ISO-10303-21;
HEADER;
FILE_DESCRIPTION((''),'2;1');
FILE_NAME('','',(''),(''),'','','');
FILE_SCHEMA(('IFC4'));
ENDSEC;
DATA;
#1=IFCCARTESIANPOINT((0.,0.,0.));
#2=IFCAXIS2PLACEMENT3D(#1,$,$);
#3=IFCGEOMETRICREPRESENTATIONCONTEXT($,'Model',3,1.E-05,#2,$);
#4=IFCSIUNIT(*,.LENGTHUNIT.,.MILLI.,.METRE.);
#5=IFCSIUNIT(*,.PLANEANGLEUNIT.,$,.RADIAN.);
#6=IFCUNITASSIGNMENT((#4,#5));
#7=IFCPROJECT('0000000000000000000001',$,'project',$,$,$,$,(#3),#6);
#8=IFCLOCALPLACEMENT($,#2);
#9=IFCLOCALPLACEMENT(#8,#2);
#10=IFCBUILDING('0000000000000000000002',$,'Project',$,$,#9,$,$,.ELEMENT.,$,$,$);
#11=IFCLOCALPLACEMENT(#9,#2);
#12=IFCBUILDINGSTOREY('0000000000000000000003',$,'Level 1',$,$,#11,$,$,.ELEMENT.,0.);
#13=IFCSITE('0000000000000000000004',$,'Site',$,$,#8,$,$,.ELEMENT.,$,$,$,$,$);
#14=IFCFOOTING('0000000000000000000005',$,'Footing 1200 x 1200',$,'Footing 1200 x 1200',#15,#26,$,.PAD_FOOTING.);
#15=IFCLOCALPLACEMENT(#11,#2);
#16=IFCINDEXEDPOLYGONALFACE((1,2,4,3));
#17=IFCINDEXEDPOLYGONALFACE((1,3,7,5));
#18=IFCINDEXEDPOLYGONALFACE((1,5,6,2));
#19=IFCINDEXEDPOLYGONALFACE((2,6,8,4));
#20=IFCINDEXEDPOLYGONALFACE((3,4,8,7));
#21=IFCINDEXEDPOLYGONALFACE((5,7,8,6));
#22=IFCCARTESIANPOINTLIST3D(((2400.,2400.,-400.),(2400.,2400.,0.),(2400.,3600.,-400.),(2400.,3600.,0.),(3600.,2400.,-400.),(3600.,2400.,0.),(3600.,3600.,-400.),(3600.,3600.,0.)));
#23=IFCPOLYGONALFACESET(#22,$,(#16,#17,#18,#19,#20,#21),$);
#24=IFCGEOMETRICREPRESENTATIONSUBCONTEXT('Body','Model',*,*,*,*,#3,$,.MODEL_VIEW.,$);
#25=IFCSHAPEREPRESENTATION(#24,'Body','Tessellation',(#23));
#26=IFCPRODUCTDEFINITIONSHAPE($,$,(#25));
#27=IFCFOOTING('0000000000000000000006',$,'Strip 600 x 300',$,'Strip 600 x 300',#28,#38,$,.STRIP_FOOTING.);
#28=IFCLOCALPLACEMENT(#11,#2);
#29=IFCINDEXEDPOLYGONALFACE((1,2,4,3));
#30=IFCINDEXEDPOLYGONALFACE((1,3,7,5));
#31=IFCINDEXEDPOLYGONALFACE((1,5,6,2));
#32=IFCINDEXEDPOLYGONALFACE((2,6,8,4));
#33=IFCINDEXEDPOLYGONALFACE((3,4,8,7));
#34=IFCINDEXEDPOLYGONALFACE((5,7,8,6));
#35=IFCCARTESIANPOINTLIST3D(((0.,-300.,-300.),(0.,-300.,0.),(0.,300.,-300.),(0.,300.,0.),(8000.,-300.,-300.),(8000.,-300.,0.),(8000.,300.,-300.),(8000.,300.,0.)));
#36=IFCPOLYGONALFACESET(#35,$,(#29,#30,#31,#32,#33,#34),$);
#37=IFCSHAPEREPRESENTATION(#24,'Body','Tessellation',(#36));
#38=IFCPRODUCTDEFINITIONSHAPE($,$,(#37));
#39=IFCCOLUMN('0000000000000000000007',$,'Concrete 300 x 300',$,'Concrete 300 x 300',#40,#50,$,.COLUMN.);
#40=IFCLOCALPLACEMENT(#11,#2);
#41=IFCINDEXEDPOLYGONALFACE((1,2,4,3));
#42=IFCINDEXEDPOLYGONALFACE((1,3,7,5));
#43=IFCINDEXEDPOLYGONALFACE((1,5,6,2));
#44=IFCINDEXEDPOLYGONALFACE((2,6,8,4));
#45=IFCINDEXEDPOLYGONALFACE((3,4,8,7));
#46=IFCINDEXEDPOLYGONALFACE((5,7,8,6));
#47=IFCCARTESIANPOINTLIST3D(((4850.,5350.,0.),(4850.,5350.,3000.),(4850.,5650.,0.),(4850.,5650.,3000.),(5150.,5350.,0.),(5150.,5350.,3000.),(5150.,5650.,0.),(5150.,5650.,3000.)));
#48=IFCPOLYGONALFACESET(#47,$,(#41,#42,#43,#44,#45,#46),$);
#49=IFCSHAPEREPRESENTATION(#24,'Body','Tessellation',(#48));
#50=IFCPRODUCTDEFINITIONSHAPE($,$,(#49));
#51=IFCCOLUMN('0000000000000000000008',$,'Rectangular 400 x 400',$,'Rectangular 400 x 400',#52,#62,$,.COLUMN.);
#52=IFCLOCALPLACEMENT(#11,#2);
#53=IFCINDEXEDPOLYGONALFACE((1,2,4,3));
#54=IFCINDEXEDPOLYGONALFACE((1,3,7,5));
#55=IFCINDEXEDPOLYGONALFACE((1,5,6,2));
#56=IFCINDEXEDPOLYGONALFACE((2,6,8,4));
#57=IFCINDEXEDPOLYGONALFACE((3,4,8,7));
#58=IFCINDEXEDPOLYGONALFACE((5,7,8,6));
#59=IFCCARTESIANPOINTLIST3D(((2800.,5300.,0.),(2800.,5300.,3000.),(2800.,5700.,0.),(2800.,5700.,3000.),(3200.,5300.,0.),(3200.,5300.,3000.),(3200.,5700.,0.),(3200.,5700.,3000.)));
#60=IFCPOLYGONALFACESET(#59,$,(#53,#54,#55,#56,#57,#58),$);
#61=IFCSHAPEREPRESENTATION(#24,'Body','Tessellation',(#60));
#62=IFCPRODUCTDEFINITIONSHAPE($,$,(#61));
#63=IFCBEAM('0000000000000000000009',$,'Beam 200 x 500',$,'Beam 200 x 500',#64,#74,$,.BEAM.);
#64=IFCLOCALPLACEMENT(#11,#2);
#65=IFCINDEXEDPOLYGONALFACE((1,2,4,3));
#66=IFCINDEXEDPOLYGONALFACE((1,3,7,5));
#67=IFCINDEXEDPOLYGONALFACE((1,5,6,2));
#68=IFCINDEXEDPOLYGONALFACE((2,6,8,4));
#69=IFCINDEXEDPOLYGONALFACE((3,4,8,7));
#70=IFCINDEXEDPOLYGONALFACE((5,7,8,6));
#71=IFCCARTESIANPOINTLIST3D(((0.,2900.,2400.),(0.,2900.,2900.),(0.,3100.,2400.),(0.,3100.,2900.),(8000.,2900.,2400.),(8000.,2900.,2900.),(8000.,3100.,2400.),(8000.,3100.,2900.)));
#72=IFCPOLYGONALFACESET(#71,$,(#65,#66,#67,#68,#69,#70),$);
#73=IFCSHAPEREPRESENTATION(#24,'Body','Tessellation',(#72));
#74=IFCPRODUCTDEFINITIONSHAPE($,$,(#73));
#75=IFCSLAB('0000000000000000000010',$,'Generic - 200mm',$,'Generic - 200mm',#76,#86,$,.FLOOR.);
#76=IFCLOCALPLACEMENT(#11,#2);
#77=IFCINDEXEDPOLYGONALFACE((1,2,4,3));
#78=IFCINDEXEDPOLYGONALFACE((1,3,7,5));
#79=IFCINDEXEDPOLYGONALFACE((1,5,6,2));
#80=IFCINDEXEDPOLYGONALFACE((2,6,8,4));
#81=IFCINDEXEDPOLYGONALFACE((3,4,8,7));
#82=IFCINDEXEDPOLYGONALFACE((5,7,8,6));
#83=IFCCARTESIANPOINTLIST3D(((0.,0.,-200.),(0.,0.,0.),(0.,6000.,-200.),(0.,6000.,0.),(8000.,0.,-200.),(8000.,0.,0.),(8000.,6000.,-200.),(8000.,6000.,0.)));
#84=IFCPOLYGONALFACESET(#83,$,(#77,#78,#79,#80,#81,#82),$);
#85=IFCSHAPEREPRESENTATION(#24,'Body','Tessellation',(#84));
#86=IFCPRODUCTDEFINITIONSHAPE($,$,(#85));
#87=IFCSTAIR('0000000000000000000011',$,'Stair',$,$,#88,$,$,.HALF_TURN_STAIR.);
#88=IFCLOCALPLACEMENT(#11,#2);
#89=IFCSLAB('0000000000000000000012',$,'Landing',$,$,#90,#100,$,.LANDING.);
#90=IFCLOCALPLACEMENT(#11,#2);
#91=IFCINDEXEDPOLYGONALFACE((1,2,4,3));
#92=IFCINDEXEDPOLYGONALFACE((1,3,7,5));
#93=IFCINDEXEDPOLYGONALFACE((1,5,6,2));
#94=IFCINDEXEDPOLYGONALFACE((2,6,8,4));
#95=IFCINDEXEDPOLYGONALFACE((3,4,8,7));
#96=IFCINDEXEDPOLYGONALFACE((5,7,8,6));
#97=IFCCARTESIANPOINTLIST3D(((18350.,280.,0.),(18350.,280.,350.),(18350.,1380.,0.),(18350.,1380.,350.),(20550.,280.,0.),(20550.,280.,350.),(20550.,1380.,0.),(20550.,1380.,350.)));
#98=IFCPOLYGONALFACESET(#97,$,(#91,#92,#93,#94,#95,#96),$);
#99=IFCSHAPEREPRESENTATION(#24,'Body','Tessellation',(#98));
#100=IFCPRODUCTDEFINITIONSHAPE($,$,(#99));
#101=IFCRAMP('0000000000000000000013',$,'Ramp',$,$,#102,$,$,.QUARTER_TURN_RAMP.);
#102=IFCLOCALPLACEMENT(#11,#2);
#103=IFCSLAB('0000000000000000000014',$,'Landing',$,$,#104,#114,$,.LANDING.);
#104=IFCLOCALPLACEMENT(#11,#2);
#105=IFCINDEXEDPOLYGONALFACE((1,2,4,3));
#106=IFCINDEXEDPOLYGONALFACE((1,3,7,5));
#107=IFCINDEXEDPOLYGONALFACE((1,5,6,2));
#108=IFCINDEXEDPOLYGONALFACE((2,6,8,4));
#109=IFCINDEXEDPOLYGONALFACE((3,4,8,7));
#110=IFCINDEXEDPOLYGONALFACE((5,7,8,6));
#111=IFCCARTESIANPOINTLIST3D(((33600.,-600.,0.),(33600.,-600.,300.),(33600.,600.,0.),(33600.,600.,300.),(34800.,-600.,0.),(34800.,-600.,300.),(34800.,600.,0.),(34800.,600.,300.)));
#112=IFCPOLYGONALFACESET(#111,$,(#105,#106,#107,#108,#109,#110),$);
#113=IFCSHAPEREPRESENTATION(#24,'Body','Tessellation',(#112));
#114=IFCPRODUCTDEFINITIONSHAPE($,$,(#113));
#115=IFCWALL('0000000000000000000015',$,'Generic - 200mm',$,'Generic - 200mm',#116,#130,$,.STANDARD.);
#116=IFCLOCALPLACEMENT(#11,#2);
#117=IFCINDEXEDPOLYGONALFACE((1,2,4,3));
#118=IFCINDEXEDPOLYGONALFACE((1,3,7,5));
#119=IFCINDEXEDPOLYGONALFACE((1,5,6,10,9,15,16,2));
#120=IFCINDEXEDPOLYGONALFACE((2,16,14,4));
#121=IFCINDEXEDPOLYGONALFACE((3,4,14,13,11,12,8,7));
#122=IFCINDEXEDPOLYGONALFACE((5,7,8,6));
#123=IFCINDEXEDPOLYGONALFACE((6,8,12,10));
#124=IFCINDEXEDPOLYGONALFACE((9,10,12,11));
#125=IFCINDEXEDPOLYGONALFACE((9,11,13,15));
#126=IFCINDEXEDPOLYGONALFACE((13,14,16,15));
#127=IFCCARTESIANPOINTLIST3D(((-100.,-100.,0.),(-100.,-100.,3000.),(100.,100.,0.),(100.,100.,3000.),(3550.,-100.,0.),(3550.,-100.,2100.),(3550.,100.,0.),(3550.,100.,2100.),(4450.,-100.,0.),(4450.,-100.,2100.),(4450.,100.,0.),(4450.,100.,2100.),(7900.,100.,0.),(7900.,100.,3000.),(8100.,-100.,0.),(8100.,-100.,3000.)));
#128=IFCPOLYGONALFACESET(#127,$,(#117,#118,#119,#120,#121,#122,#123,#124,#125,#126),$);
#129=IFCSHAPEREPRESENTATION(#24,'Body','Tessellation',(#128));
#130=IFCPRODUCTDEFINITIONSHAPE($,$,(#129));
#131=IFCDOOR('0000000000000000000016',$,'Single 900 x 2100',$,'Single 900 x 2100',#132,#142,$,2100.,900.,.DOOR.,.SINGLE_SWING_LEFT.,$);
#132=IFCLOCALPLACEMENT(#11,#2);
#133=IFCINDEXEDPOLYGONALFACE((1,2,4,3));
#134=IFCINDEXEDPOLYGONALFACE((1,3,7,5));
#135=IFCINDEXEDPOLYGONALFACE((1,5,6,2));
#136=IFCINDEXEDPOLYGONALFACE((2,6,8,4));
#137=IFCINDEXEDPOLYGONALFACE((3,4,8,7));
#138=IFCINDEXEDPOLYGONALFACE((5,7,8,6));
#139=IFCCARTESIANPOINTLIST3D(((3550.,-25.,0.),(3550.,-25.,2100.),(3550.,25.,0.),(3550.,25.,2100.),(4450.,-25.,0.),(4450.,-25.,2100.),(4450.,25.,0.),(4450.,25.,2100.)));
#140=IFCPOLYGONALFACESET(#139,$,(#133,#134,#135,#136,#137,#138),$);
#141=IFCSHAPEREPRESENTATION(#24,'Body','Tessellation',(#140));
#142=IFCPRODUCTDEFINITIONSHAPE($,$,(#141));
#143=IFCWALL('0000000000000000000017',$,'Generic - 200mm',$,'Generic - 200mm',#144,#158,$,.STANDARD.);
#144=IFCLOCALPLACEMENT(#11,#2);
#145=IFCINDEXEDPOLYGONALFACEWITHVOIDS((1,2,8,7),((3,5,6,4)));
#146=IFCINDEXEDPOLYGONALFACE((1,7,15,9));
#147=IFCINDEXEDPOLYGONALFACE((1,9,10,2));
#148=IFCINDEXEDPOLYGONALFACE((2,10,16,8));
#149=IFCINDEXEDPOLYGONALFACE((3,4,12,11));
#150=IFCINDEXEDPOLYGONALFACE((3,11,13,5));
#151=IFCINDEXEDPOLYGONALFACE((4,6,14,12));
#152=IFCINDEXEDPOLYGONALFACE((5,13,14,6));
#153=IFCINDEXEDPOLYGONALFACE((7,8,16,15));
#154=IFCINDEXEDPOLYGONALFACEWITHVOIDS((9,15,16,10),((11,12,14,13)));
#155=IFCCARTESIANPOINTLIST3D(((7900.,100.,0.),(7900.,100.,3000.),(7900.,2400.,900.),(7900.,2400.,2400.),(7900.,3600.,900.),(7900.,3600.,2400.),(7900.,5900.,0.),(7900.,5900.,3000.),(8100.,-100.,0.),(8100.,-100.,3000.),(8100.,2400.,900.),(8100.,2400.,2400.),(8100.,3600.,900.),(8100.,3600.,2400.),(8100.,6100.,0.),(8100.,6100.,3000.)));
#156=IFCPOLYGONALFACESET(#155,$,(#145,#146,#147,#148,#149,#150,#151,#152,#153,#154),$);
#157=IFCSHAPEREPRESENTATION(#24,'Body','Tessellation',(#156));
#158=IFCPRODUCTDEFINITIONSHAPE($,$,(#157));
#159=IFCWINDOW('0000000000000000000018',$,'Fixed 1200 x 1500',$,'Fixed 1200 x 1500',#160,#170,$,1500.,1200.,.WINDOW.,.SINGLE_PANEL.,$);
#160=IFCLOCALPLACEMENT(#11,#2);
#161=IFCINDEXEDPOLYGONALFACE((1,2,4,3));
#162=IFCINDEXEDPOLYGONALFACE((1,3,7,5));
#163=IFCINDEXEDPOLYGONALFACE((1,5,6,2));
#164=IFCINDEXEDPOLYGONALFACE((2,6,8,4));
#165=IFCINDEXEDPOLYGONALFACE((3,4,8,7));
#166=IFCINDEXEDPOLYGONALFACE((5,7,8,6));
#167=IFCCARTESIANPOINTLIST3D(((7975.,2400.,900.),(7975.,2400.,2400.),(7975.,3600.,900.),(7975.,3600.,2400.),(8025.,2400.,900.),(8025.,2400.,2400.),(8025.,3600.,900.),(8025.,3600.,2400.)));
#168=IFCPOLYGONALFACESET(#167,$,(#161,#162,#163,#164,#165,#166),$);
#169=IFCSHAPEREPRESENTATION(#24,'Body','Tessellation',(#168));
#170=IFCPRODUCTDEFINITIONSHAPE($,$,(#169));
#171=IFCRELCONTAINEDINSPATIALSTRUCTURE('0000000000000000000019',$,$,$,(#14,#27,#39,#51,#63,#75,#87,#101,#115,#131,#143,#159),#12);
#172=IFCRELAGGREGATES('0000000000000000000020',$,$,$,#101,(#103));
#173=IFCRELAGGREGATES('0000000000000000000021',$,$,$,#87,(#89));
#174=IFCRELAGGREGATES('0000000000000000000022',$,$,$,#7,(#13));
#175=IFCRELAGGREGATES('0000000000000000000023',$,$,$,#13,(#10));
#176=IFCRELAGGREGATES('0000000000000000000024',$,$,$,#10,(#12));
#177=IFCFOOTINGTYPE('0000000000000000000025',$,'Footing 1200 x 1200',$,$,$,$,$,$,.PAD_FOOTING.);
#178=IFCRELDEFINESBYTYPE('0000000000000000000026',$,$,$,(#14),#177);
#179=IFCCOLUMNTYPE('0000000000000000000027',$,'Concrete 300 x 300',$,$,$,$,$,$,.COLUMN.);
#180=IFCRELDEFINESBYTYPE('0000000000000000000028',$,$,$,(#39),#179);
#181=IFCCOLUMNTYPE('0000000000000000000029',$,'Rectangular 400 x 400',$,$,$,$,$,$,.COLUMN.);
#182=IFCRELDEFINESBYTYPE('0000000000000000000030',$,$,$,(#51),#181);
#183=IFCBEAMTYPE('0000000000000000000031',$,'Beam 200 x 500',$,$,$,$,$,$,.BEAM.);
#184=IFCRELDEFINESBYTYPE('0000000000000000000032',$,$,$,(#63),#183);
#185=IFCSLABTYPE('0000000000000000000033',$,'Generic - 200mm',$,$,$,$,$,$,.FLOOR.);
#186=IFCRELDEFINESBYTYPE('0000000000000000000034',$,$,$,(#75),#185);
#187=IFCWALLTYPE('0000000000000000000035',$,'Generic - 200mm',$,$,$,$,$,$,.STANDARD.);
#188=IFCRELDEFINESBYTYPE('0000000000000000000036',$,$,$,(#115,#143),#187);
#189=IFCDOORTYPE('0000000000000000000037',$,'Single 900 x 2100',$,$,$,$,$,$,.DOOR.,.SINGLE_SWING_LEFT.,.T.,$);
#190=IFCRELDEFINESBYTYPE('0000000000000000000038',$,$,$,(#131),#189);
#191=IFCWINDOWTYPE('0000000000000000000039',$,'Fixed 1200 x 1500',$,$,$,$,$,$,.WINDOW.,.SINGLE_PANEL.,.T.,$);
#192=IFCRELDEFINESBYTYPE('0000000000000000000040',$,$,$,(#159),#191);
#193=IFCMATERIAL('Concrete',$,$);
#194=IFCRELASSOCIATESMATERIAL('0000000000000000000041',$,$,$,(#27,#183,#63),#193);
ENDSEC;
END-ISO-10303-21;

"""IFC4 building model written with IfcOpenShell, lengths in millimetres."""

from ifc_helpers import new_model, si_unit, frame, frame_2d, origin, origin_with_axes, origin_2d, place, context, subcontext, project, spatial, polyline, rectangle, outline, extrude, material, material_profile, profile_set, profile_usage, type_object, element, fill, aggregate, save


model = new_model("IFC4")

# Units and contexts
model_context = context("Model", 3, precision=1e-05, world=origin())
body_context = subcontext(model_context, "Body", "Model", "MODEL_VIEW")
ifc_project = project(units=[si_unit("LENGTHUNIT", "METRE", prefix="MILLI"), si_unit("PLANEANGLEUNIT", "RADIAN")], contexts=[model_context])

# Site, building, storey
site_placement = place(None, origin())
site = spatial("IfcSite", under=ifc_project, at=site_placement, Name="Site", CompositionType="ELEMENT")
building_placement = place(site_placement, origin())
building = spatial("IfcBuilding", under=site, at=building_placement, Name="Project", CompositionType="ELEMENT")
storey_placement = place(building_placement, origin())
storey = spatial("IfcBuildingStorey", under=building, at=storey_placement, Name="Level 1", CompositionType="ELEMENT", Elevation=0.0)

# Footings
ifc_material_profile_1 = material_profile(None, rectangle(XDim=1200.0, YDim=1200.0, at=origin_2d()), Name="Footing 1200 x 1200")
ifc_profile_set_1 = profile_set([ifc_material_profile_1], Name="Footing 1200 x 1200")
ifc_profile_usage_1 = profile_usage(ifc_profile_set_1, cardinal=5)
footing_type = type_object("IfcFootingType", Name="Footing 1200 x 1200", PredefinedType="PAD_FOOTING", material=ifc_profile_set_1)
footing_1_placement = place(storey_placement, frame((3000.0, 3000.0, -400.0), z_axis=(0.0, 0.0, 1.0), x_axis=(1.0, 0.0, 0.0)))
element("IfcFooting", 1, at=footing_1_placement, inside=storey, type_object=footing_type, material=ifc_profile_usage_1, Name="Footing 1200 x 1200", ObjectType="Footing 1200 x 1200", PredefinedType="PAD_FOOTING", context=body_context, shape_type="SweptSolid", body=[
    extrude(rectangle(XDim=1200.0, YDim=1200.0, at=origin_2d()), origin(), (0.0, 0.0, 1.0), 400.0),
])
ifc_material_1 = material(Name="Concrete")
footing_2_placement = place(storey_placement, frame((0.0, 0.0, -150.0)))
element("IfcFooting", 2, at=footing_2_placement, inside=storey, material=ifc_material_1, Name="Strip 600 x 300", ObjectType="Strip 600 x 300", PredefinedType="STRIP_FOOTING", context=body_context, shape_type="SweptSolid", body=[
    extrude(rectangle(XDim=600.0, YDim=300.0, at=origin_2d()), frame((0.0, 0.0, 0.0), z_axis=(1.0, 0.0, 0.0), x_axis=(0.0, 1.0, 0.0)), (0.0, 0.0, 1.0), 8000.0),
])

# Columns
ifc_material_profile_2 = material_profile(None, rectangle(XDim=300.0, YDim=300.0, at=origin_2d()), Name="Concrete 300 x 300")
ifc_profile_set_2 = profile_set([ifc_material_profile_2], Name="Concrete 300 x 300")
ifc_profile_usage_2 = profile_usage(ifc_profile_set_2, cardinal=5)
column_type_1 = type_object("IfcColumnType", Name="Concrete 300 x 300", PredefinedType="COLUMN", material=ifc_profile_set_2)
column_1_placement = place(storey_placement, frame((5000.0, 5500.0, 0.0), z_axis=(0.0, 0.0, 1.0), x_axis=(1.0, 0.0, 0.0)))
element("IfcColumn", 3, at=column_1_placement, inside=storey, type_object=column_type_1, material=ifc_profile_usage_2, Name="Concrete 300 x 300", ObjectType="Concrete 300 x 300", PredefinedType="COLUMN", context=body_context, shape_type="SweptSolid", body=[
    extrude(rectangle(XDim=300.0, YDim=300.0, at=origin_2d()), origin(), (0.0, 0.0, 1.0), 3000.0),
])
ifc_material_profile_3 = material_profile(None, rectangle(XDim=400.0, YDim=400.0, at=origin_2d()), Name="Rectangular 400 x 400")
ifc_profile_set_3 = profile_set([ifc_material_profile_3], Name="Rectangular 400 x 400")
ifc_profile_usage_3 = profile_usage(ifc_profile_set_3, cardinal=5)
column_type_2 = type_object("IfcColumnType", Name="Rectangular 400 x 400", PredefinedType="COLUMN", material=ifc_profile_set_3)
column_2_placement = place(storey_placement, frame((3000.0, 5500.0, 0.0), z_axis=(0.0, 0.0, 1.0), x_axis=(1.0, 0.0, 0.0)))
element("IfcColumn", 4, at=column_2_placement, inside=storey, type_object=column_type_2, material=ifc_profile_usage_3, Name="Rectangular 400 x 400", ObjectType="Rectangular 400 x 400", PredefinedType="COLUMN", context=body_context, shape_type="SweptSolid", body=[
    extrude(rectangle(XDim=400.0, YDim=400.0, at=origin_2d()), origin(), (0.0, 0.0, 1.0), 3000.0),
])

# Beam
ifc_material_profile_4 = material_profile(ifc_material_1, rectangle(XDim=200.0, YDim=500.0, at=origin_2d()), Name="Beam 200 x 500")
ifc_profile_set_4 = profile_set([ifc_material_profile_4], Name="Beam 200 x 500")
ifc_profile_usage_4 = profile_usage(ifc_profile_set_4, cardinal=8)
beam_type = type_object("IfcBeamType", Name="Beam 200 x 500", PredefinedType="BEAM", material=ifc_profile_set_4)
beam_placement = place(storey_placement, frame((0.0, 3000.0, 2650.0)))
element("IfcBeam", 5, at=beam_placement, inside=storey, type_object=beam_type, material=ifc_profile_usage_4, Name="Beam 200 x 500", ObjectType="Beam 200 x 500", PredefinedType="BEAM", context=body_context, shape_type="SweptSolid", body=[
    extrude(rectangle(XDim=200.0, YDim=500.0, at=origin_2d()), frame((0.0, 0.0, 0.0), z_axis=(1.0, 0.0, 0.0), x_axis=(0.0, 1.0, 0.0)), (0.0, 0.0, 1.0), 8000.0),
])

# Slab
slab_type = type_object("IfcSlabType", Name="Generic - 200mm", PredefinedType="FLOOR")
slab_1_placement = place(storey_placement, origin())
element("IfcSlab", 6, at=slab_1_placement, inside=storey, type_object=slab_type, Name="Generic - 200mm", ObjectType="Generic - 200mm", PredefinedType="FLOOR", context=body_context, shape_type="SweptSolid", body=[
    extrude(outline(polyline([(8000.0, 6000.0), (0.0, 6000.0), (0.0, 0.0), (8000.0, 0.0), (8000.0, 6000.0)])), frame((0.0, 0.0, -200.0)), (0.0, 0.0, 1.0), 200.0),
])

# Stair, slab
stair_placement = place(storey_placement, origin())
stair = element("IfcStair", 7, at=stair_placement, inside=storey, Name="Stair", PredefinedType="HALF_TURN_STAIR")
slab_2_placement = place(stair_placement, origin())
slab_2 = element("IfcSlab", 8, at=slab_2_placement, Name="Landing", PredefinedType="LANDING", context=body_context, shape_type="SweptSolid", body=[
    extrude(outline(polyline([(20550.0, 280.0), (20550.0, 1380.0), (18350.0, 1380.0), (18350.0, 280.0), (20550.0, 280.0)])), origin(), (0.0, 0.0, 1.0), 350.0),
])

# Ramp, slab
ramp_placement = place(storey_placement, origin())
ramp = element("IfcRamp", 9, at=ramp_placement, inside=storey, Name="Ramp", PredefinedType="QUARTER_TURN_RAMP")
slab_3_placement = place(ramp_placement, origin())
slab_3 = element("IfcSlab", 10, at=slab_3_placement, Name="Landing", PredefinedType="LANDING", context=body_context, shape_type="SweptSolid", body=[
    extrude(outline(polyline([(33600.0, -600.0), (34800.0, -600.0), (34800.0, 600.0), (33600.0, 600.0), (33600.0, -600.0)])), origin(), (0.0, 0.0, 1.0), 300.0),
])
aggregate(ramp, [slab_3])

# Wall, opening, door
wall_type = type_object("IfcWallType", Name="Generic - 200mm", PredefinedType="STANDARD")
wall_1_placement = place(storey_placement, origin_with_axes())
wall_1 = element("IfcWall", 11, at=wall_1_placement, inside=storey, type_object=wall_type, Name="Generic - 200mm", ObjectType="Generic - 200mm", PredefinedType="STANDARD", context=body_context, shape_type="SweptSolid", body=[
    extrude(outline(polyline([(-100.0, -100.0), (0.0, 0.0), (100.0, 100.0), (7900.0, 100.0), (8000.0, 0.0), (8100.0, -100.0), (-100.0, -100.0)])), origin(), (0.0, 0.0, 1.0), 3000.0),
])
opening_1_placement = place(wall_1_placement, frame((3550.0, 0.0, 0.0), z_axis=(0.0, 0.0, 1.0), x_axis=(1.0, 0.0, 0.0)))
opening_1 = element("IfcOpeningElement", 12, at=opening_1_placement, cuts=wall_1, PredefinedType="OPENING", context=body_context, shape_type="SweptSolid", body=[
    extrude(rectangle(XDim=900.0, YDim=220.0, at=frame_2d((450.0, 0.0))), origin(), (0.0, 0.0, 1.0), 2100.0),
])
door_type = type_object("IfcDoorType", Name="Single 900 x 2100", OperationType="SINGLE_SWING_LEFT", ParameterTakesPrecedence=True, PredefinedType="DOOR")
door_placement = place(opening_1_placement, origin())
door = element("IfcDoor", 13, at=door_placement, inside=storey, type_object=door_type, Name="Single 900 x 2100", ObjectType="Single 900 x 2100", OperationType="SINGLE_SWING_LEFT", OverallHeight=2100.0, OverallWidth=900.0, PredefinedType="DOOR", context=body_context, shape_type="SweptSolid", body=[
    extrude(rectangle(XDim=900.0, YDim=50.0, at=frame_2d((450.0, 0.0))), origin(), (0.0, 0.0, 1.0), 2100.0),
])
fill(opening_1, door)

# Wall, opening, window
wall_2_placement = place(storey_placement, frame((8000.0, 0.0, 0.0), z_axis=(0.0, 0.0, 1.0), x_axis=(0.0, 1.0, 0.0)))
wall_2 = element("IfcWall", 14, at=wall_2_placement, inside=storey, type_object=wall_type, Name="Generic - 200mm", ObjectType="Generic - 200mm", PredefinedType="STANDARD", context=body_context, shape_type="SweptSolid", body=[
    extrude(outline(polyline([(-100.0, -100.0), (0.0, 0.0), (100.0, 100.0), (5900.0, 100.0), (6000.0, 0.0), (6100.0, -100.0), (-100.0, -100.0)])), origin(), (0.0, 0.0, 1.0), 3000.0),
])
opening_2_placement = place(wall_2_placement, frame((2400.0, 0.0, 900.0), z_axis=(0.0, 0.0, 1.0), x_axis=(1.0, 0.0, 0.0)))
opening_2 = element("IfcOpeningElement", 15, at=opening_2_placement, cuts=wall_2, PredefinedType="OPENING", context=body_context, shape_type="SweptSolid", body=[
    extrude(rectangle(XDim=1200.0, YDim=220.0, at=frame_2d((600.0, 0.0))), origin(), (0.0, 0.0, 1.0), 1500.0),
])
window_type = type_object("IfcWindowType", Name="Fixed 1200 x 1500", ParameterTakesPrecedence=True, PartitioningType="SINGLE_PANEL", PredefinedType="WINDOW")
window_placement = place(opening_2_placement, origin())
window = element("IfcWindow", 16, at=window_placement, inside=storey, type_object=window_type, Name="Fixed 1200 x 1500", ObjectType="Fixed 1200 x 1500", OverallHeight=1500.0, OverallWidth=1200.0, PartitioningType="SINGLE_PANEL", PredefinedType="WINDOW", context=body_context, shape_type="SweptSolid", body=[
    extrude(rectangle(XDim=1200.0, YDim=50.0, at=frame_2d((600.0, 0.0))), origin(), (0.0, 0.0, 1.0), 1500.0),
])
fill(opening_2, window)

aggregate(stair, [slab_2])

save(model, "model.ifc")
